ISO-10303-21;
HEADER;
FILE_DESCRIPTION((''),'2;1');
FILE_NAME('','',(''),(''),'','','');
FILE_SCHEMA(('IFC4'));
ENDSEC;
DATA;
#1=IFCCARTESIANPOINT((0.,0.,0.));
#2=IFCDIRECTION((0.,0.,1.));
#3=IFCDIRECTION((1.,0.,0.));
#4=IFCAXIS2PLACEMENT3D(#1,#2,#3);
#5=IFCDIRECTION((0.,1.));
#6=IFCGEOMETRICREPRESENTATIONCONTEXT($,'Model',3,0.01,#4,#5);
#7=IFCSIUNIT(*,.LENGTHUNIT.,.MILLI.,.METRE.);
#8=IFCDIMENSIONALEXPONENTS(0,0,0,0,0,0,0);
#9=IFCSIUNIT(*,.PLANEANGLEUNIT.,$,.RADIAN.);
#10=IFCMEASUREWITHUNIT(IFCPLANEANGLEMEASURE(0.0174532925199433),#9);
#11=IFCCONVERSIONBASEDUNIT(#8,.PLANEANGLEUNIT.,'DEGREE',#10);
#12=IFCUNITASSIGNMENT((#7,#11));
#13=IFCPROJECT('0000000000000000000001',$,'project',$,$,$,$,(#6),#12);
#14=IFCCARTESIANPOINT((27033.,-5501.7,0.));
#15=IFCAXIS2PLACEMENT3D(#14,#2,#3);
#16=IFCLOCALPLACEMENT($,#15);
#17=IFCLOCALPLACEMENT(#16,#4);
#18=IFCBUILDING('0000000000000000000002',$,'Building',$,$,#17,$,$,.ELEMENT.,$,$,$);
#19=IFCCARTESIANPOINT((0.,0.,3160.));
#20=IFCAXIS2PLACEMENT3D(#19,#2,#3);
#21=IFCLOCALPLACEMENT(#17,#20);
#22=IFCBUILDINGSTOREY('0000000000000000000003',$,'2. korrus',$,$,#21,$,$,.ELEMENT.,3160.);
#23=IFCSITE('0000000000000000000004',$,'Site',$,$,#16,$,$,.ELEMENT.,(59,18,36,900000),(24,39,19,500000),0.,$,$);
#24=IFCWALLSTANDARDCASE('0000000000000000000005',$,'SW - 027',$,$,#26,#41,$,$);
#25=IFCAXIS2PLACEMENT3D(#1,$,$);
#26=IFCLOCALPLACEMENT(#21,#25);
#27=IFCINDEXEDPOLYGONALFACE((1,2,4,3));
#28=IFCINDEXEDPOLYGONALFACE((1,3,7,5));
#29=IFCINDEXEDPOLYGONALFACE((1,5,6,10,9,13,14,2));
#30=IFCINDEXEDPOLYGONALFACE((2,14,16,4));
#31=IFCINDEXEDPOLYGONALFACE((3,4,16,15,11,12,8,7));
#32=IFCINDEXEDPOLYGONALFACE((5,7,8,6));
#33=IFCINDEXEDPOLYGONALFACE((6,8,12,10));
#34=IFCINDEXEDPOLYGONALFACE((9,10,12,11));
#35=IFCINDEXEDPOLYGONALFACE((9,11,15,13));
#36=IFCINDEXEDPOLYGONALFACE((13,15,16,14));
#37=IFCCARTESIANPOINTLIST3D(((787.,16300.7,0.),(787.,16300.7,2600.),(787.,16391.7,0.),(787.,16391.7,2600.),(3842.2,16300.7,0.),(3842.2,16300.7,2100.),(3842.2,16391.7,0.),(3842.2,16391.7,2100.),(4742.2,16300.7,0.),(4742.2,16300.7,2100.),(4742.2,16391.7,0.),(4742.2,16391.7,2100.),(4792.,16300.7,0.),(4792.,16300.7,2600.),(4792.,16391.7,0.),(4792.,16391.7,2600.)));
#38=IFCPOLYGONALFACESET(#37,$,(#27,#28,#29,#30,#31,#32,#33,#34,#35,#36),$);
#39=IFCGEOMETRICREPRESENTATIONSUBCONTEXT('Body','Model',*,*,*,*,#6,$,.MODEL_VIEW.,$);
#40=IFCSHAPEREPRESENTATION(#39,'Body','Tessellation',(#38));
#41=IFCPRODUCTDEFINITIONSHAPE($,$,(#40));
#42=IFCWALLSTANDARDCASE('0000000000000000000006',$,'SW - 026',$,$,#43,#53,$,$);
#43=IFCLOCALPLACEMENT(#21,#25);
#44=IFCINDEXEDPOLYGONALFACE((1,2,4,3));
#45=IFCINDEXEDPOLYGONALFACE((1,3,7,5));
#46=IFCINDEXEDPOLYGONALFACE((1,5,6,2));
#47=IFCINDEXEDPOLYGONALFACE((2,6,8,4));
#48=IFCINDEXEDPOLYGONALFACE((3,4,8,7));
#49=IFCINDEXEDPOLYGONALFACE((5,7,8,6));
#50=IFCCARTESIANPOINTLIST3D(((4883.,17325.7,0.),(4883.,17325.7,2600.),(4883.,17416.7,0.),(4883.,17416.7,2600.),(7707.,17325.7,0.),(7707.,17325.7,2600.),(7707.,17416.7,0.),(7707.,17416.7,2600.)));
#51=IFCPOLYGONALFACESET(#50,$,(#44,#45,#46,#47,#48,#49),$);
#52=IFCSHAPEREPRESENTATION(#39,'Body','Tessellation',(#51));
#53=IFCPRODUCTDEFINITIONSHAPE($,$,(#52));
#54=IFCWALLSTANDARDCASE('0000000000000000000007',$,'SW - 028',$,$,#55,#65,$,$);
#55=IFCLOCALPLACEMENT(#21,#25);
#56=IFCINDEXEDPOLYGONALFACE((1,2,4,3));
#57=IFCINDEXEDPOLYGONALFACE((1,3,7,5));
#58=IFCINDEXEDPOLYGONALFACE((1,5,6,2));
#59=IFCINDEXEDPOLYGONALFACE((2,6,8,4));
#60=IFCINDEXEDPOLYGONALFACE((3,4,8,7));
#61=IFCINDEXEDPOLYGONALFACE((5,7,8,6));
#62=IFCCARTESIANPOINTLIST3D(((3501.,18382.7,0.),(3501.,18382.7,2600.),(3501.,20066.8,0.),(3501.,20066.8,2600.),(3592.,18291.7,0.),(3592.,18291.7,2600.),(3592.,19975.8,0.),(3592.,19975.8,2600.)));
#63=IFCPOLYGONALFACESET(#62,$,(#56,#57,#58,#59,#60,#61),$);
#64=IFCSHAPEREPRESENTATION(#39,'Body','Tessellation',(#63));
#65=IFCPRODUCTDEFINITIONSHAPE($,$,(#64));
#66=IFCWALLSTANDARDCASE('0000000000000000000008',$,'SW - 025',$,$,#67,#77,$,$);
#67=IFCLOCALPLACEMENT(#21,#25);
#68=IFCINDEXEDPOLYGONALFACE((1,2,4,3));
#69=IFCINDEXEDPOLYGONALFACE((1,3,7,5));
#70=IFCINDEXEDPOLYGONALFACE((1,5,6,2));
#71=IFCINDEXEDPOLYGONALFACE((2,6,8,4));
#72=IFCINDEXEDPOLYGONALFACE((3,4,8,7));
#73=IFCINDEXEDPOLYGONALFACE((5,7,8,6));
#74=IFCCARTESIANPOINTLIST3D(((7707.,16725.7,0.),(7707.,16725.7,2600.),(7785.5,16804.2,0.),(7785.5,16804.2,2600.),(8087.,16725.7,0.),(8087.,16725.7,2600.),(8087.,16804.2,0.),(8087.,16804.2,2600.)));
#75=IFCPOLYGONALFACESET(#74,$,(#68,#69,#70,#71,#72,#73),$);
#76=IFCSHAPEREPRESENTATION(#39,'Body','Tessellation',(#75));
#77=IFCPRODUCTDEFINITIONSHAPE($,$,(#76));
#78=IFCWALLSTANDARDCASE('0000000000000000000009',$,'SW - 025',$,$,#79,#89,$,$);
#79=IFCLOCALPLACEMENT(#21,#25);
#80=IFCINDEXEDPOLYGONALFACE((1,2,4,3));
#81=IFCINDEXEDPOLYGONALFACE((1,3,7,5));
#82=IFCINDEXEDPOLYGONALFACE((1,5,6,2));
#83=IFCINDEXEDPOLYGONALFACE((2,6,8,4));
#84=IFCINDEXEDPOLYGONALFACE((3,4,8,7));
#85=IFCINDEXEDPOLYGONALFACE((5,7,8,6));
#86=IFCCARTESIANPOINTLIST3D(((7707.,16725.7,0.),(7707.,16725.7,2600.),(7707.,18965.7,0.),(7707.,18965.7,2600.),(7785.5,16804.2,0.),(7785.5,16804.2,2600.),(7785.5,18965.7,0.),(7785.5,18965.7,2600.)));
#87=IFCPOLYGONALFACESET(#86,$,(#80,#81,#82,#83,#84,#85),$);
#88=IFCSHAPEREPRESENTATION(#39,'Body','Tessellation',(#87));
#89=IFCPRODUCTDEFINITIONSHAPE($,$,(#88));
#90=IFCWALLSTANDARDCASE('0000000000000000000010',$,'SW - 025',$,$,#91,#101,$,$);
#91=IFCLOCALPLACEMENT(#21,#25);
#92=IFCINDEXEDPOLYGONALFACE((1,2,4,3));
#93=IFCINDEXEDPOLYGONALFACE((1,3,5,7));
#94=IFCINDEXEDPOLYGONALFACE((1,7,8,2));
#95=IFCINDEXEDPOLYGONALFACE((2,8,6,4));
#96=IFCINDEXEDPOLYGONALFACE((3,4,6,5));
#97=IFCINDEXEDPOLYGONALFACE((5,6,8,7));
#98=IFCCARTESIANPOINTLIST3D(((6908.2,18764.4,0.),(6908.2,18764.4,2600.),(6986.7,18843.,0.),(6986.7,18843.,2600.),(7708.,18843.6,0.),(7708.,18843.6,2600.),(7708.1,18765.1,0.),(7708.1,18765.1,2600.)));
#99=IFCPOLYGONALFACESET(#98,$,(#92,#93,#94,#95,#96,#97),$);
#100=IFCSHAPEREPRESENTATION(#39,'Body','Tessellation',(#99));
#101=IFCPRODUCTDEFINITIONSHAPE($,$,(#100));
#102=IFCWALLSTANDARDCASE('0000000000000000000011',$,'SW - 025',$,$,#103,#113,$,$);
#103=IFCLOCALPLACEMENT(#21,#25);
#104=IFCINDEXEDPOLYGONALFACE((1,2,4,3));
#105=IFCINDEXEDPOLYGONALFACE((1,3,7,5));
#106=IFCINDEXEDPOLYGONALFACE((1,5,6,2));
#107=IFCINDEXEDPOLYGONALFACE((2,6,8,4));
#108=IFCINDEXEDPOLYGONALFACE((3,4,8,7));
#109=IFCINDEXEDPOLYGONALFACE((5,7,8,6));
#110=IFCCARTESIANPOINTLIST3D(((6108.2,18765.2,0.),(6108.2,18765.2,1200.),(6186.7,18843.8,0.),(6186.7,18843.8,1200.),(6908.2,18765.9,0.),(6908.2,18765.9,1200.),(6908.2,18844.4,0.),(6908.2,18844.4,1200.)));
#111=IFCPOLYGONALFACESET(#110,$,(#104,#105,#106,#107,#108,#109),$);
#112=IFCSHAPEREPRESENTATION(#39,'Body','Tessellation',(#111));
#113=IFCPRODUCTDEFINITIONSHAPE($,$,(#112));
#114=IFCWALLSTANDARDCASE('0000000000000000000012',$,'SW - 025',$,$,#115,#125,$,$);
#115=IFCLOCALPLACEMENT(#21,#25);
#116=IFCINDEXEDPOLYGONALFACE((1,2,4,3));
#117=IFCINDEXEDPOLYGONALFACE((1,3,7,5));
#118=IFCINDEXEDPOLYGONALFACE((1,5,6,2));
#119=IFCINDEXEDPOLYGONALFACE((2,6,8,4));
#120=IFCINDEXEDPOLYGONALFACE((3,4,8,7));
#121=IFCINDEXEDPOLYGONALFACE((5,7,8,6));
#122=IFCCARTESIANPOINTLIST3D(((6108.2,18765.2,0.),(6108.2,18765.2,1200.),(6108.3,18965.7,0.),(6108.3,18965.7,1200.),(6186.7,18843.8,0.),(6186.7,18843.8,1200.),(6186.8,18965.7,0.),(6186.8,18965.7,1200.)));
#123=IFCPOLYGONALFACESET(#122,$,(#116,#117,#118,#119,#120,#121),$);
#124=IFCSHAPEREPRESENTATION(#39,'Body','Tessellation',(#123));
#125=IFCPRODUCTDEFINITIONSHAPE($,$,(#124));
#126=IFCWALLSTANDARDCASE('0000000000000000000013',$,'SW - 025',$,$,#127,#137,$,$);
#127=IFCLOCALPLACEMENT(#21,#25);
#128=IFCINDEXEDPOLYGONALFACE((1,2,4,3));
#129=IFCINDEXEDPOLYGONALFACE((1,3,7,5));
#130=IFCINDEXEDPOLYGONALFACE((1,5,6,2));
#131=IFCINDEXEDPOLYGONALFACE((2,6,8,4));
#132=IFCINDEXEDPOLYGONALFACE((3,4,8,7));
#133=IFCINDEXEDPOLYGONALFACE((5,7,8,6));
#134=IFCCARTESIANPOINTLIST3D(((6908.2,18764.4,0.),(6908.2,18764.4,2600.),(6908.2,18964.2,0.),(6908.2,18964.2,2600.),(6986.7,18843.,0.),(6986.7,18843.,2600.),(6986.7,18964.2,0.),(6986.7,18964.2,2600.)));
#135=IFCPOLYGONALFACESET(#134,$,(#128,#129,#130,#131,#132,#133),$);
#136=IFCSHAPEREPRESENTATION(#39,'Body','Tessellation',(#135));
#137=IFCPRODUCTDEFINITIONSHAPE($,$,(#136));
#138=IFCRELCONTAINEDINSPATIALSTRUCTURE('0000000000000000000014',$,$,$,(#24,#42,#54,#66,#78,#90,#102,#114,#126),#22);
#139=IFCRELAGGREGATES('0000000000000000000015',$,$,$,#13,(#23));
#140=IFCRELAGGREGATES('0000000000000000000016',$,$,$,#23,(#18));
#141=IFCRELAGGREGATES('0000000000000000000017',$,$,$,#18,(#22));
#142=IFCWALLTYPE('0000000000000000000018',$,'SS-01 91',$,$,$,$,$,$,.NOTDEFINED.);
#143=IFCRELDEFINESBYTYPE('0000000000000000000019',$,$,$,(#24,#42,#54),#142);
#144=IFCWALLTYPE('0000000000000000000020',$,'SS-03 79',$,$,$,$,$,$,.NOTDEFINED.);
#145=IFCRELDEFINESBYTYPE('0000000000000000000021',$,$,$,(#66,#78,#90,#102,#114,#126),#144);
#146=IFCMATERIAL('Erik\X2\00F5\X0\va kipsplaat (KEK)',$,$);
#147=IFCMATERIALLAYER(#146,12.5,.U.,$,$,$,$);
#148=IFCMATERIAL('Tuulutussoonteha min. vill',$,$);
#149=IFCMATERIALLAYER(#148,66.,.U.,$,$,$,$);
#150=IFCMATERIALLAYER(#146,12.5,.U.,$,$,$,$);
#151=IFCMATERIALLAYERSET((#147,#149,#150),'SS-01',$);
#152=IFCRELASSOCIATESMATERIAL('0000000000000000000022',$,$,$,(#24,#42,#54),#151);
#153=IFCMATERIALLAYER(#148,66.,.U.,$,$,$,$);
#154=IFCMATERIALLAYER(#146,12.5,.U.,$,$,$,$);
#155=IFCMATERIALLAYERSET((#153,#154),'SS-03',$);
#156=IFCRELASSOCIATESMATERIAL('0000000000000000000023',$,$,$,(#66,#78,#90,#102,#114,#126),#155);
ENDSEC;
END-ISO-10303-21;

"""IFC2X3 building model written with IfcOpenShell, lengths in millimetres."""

from ifc_helpers import new_model, entity, si_unit, converted_unit, direction, frame, origin_with_axes, origin_2d_with_axis, place, context, subcontext, project, spatial, polyline, rectangle, outline, extrude, material, layer, layer_set, layer_usage, type_object, element, save


model = new_model("IFC2X3")

# Units and contexts
model_context = context("Model", 3, precision=0.01, world=origin_with_axes(), true_north=direction((0.0, 1.0)))
body_context = subcontext(model_context, "Body", "Model", "MODEL_VIEW")
ifc_project = project(units=[si_unit("LENGTHUNIT", "METRE", prefix="MILLI"), converted_unit("PLANEANGLEUNIT", "DEGREE", entity("IfcPlaneAngleMeasure", 0.0174532925199433), si_unit("PLANEANGLEUNIT", "RADIAN"), dimensions=[0, 0, 0, 0, 0, 0, 0])], contexts=[model_context])

# Site, building, storey
site_placement = place(None, frame((27033.0, -5501.7, 0.0), z_axis=(0.0, 0.0, 1.0), x_axis=(1.0, 0.0, 0.0)))
site = spatial("IfcSite", under=ifc_project, at=site_placement, Name="Site", CompositionType="ELEMENT", RefLatitude=(59, 18, 36, 900000), RefLongitude=(24, 39, 19, 500000), RefElevation=0.0)
building_placement = place(site_placement, origin_with_axes())
building = spatial("IfcBuilding", under=site, at=building_placement, Name="Building", CompositionType="ELEMENT")
storey_placement = place(building_placement, frame((0.0, 0.0, 3160.0), z_axis=(0.0, 0.0, 1.0), x_axis=(1.0, 0.0, 0.0)))
storey = spatial("IfcBuildingStorey", under=building, at=storey_placement, Name="2. korrus", CompositionType="ELEMENT", Elevation=3160.0)

# Shared definitions
ifc_material_1 = material(Name="Erikõva kipsplaat (KEK)")
ifc_layer_1 = layer(ifc_material_1, 12.5, ventilated="UNKNOWN")
ifc_material_2 = material(Name="Tuulutussoonteha min. vill")
ifc_layer_2 = layer(ifc_material_2, 66.0, ventilated="UNKNOWN")
ifc_layer_3 = layer(ifc_material_1, 12.5, ventilated="UNKNOWN")
ifc_layer_set_1 = layer_set([ifc_layer_1, ifc_layer_2, ifc_layer_3], Name="SS-01")
wall_type_1 = type_object("IfcWallType", Name="SS-01 91", PredefinedType="NOTDEFINED")

# Wall, opening
ifc_layer_usage_1 = layer_usage(ifc_layer_set_1, "AXIS2", "NEGATIVE", 91.0)
wall_1_placement = place(storey_placement, frame((4792.0, 16391.7, 0.0), z_axis=(0.0, 0.0, 1.0), x_axis=(-1.0, 0.0, 0.0)))
wall_1 = element("IfcWallStandardCase", 1, at=wall_1_placement, inside=storey, type_object=wall_type_1, material=ifc_layer_usage_1, Name="SW - 027", context=body_context, shape_type="SweptSolid", body=[
    extrude(outline(polyline([(0.0, 0.0), (4005.0, 0.0), (4005.0, 91.0), (0.0, 91.0), (0.0, 0.0)])), origin_with_axes(), (0.0, 0.0, 1.0), 2600.0),
])
opening_1_placement = place(wall_1_placement, frame((499.8, 0.0, 0.0), z_axis=(0.0, 0.0, 1.0), x_axis=(1.0, 0.0, 0.0)))
element("IfcOpeningElement", 2, at=opening_1_placement, cuts=wall_1, context=body_context, shape_type="SweptSolid", body=[
    extrude(rectangle(XDim=900.0, YDim=2100.0, at=origin_2d_with_axis()), frame((0.0, 91.0, 1050.0), z_axis=(0.0, 1.0, 0.0), x_axis=(-1.0, 0.0, 0.0)), (0.0, 0.0, -1.0), 273.0),
    extrude(rectangle(XDim=974.0, YDim=2137.0, at=origin_2d_with_axis()), frame((0.0, 0.0, 1068.5), z_axis=(0.0, -1.0, 0.0), x_axis=(-1.0, 0.0, 0.0)), (0.0, 0.0, 1.0), 91.0),
])

# Wall
ifc_layer_usage_2 = layer_usage(ifc_layer_set_1, "AXIS2", "POSITIVE", -91.0)
wall_2_placement = place(storey_placement, frame((7707.0, 17325.7, 0.0), z_axis=(0.0, 0.0, 1.0), x_axis=(-1.0, 0.0, 0.0)))
element("IfcWallStandardCase", 3, at=wall_2_placement, inside=storey, type_object=wall_type_1, material=ifc_layer_usage_2, Name="SW - 026", context=body_context, shape_type="SweptSolid", body=[
    extrude(outline(polyline([(0.0, -91.0), (2824.0, -91.0), (2824.0, 0.0), (0.0, 0.0), (0.0, -91.0)])), origin_with_axes(), (0.0, 0.0, 1.0), 2600.0),
])

# Wall
ifc_layer_usage_3 = layer_usage(ifc_layer_set_1, "AXIS2", "NEGATIVE", 91.0)
wall_3_placement = place(storey_placement, frame((3592.0, 18291.7, 0.0), z_axis=(0.0, 0.0, 1.0), x_axis=(0.0, 1.0, 0.0)))
element("IfcWallStandardCase", 4, at=wall_3_placement, inside=storey, type_object=wall_type_1, material=ifc_layer_usage_3, Name="SW - 028", context=body_context, shape_type="SweptSolid", body=[
    extrude(outline(polyline([(0.0, 0.0), (1684.1, 0.0), (1775.1, 91.0), (91.0, 91.0), (0.0, 0.0)])), origin_with_axes(), (0.0, 0.0, 1.0), 2600.0),
])

# Walls
ifc_layer_4 = layer(ifc_material_2, 66.0, ventilated="UNKNOWN")
ifc_layer_5 = layer(ifc_material_1, 12.5, ventilated="UNKNOWN")
ifc_layer_set_2 = layer_set([ifc_layer_4, ifc_layer_5], Name="SS-03")
ifc_layer_usage_4 = layer_usage(ifc_layer_set_2, "AXIS2", "NEGATIVE", 78.5)
wall_type_2 = type_object("IfcWallType", Name="SS-03 79", PredefinedType="NOTDEFINED")
wall_4_placement = place(storey_placement, frame((7707.0, 16725.7, 0.0), z_axis=(0.0, 0.0, 1.0), x_axis=(1.0, 0.0, 0.0)))
element("IfcWallStandardCase", 5, at=wall_4_placement, inside=storey, type_object=wall_type_2, material=ifc_layer_usage_4, Name="SW - 025", context=body_context, shape_type="SweptSolid", body=[
    extrude(outline(polyline([(0.0, 0.0), (380.0, 0.0), (380.0, 78.5), (78.5, 78.5), (0.0, 0.0)])), origin_with_axes(), (0.0, 0.0, 1.0), 2600.0),
])
ifc_layer_usage_5 = layer_usage(ifc_layer_set_2, "AXIS2", "POSITIVE", -78.5)
wall_5_placement = place(storey_placement, frame((7707.0, 16725.7, 0.0), z_axis=(0.0, 0.0, 1.0), x_axis=(0.0, 1.0, 0.0)))
element("IfcWallStandardCase", 6, at=wall_5_placement, inside=storey, type_object=wall_type_2, material=ifc_layer_usage_5, Name="SW - 025", context=body_context, shape_type="SweptSolid", body=[
    extrude(outline(polyline([(78.5, -78.5), (2240.0, -78.5), (2240.0, 0.0), (0.0, 0.0), (78.5, -78.5)])), origin_with_axes(), (0.0, 0.0, 1.0), 2600.0),
])
ifc_layer_usage_6 = layer_usage(ifc_layer_set_2, "AXIS2", "POSITIVE", -78.5)
wall_6_placement = place(storey_placement, frame((7708.1, 18765.1, 0.0), z_axis=(0.0, 0.0, 1.0), x_axis=(-1.0, -0.000859, 0.0)))
element("IfcWallStandardCase", 7, at=wall_6_placement, inside=storey, type_object=wall_type_2, material=ifc_layer_usage_6, Name="SW - 025", context=body_context, shape_type="SweptSolid", body=[
    extrude(outline(polyline([(0.0, -78.5), (721.3, -78.5), (799.9, 0.0), (0.0, 0.0), (0.0, -78.5)])), origin_with_axes(), (0.0, 0.0, 1.0), 2600.0),
])
ifc_layer_usage_7 = layer_usage(ifc_layer_set_2, "AXIS2", "POSITIVE", -78.5)
wall_7_placement = place(storey_placement, frame((6908.2, 18765.9, 0.0), z_axis=(0.0, 0.0, 1.0), x_axis=(-1.0, -0.000859, 0.0)))
element("IfcWallStandardCase", 8, at=wall_7_placement, inside=storey, type_object=wall_type_2, material=ifc_layer_usage_7, Name="SW - 025", context=body_context, shape_type="SweptSolid", body=[
    extrude(outline(polyline([(-0.1, -78.5), (721.4, -78.5), (800.0, 0.0), (0.0, 0.0), (-0.1, -78.5)])), origin_with_axes(), (0.0, 0.0, 1.0), 1200.0),
])
ifc_layer_usage_8 = layer_usage(ifc_layer_set_2, "AXIS2", "POSITIVE", -78.5)
wall_8_placement = place(storey_placement, frame((6108.2, 18765.2, 0.0), z_axis=(0.0, 0.0, 1.0), x_axis=(0.000638, 1.0, 0.0)))
element("IfcWallStandardCase", 9, at=wall_8_placement, inside=storey, type_object=wall_type_2, material=ifc_layer_usage_8, Name="SW - 025", context=body_context, shape_type="SweptSolid", body=[
    extrude(outline(polyline([(78.6, -78.5), (200.5, -78.5), (200.5, 0.0), (0.0, 0.0), (78.6, -78.5)])), origin_with_axes(), (0.0, 0.0, 1.0), 1200.0),
])
ifc_layer_usage_9 = layer_usage(ifc_layer_set_2, "AXIS2", "POSITIVE", -78.5)
wall_9_placement = place(storey_placement, frame((6908.2, 18764.4, 0.0), z_axis=(0.0, 0.0, 1.0), x_axis=(0.0, 1.0, 0.0)))
element("IfcWallStandardCase", 10, at=wall_9_placement, inside=storey, type_object=wall_type_2, material=ifc_layer_usage_9, Name="SW - 025", context=body_context, shape_type="SweptSolid", body=[
    extrude(outline(polyline([(78.6, -78.5), (199.8, -78.5), (199.8, 0.0), (0.0, 0.0), (78.6, -78.5)])), origin_with_axes(), (0.0, 0.0, 1.0), 2600.0),
])

save(model, "model.ifc")
